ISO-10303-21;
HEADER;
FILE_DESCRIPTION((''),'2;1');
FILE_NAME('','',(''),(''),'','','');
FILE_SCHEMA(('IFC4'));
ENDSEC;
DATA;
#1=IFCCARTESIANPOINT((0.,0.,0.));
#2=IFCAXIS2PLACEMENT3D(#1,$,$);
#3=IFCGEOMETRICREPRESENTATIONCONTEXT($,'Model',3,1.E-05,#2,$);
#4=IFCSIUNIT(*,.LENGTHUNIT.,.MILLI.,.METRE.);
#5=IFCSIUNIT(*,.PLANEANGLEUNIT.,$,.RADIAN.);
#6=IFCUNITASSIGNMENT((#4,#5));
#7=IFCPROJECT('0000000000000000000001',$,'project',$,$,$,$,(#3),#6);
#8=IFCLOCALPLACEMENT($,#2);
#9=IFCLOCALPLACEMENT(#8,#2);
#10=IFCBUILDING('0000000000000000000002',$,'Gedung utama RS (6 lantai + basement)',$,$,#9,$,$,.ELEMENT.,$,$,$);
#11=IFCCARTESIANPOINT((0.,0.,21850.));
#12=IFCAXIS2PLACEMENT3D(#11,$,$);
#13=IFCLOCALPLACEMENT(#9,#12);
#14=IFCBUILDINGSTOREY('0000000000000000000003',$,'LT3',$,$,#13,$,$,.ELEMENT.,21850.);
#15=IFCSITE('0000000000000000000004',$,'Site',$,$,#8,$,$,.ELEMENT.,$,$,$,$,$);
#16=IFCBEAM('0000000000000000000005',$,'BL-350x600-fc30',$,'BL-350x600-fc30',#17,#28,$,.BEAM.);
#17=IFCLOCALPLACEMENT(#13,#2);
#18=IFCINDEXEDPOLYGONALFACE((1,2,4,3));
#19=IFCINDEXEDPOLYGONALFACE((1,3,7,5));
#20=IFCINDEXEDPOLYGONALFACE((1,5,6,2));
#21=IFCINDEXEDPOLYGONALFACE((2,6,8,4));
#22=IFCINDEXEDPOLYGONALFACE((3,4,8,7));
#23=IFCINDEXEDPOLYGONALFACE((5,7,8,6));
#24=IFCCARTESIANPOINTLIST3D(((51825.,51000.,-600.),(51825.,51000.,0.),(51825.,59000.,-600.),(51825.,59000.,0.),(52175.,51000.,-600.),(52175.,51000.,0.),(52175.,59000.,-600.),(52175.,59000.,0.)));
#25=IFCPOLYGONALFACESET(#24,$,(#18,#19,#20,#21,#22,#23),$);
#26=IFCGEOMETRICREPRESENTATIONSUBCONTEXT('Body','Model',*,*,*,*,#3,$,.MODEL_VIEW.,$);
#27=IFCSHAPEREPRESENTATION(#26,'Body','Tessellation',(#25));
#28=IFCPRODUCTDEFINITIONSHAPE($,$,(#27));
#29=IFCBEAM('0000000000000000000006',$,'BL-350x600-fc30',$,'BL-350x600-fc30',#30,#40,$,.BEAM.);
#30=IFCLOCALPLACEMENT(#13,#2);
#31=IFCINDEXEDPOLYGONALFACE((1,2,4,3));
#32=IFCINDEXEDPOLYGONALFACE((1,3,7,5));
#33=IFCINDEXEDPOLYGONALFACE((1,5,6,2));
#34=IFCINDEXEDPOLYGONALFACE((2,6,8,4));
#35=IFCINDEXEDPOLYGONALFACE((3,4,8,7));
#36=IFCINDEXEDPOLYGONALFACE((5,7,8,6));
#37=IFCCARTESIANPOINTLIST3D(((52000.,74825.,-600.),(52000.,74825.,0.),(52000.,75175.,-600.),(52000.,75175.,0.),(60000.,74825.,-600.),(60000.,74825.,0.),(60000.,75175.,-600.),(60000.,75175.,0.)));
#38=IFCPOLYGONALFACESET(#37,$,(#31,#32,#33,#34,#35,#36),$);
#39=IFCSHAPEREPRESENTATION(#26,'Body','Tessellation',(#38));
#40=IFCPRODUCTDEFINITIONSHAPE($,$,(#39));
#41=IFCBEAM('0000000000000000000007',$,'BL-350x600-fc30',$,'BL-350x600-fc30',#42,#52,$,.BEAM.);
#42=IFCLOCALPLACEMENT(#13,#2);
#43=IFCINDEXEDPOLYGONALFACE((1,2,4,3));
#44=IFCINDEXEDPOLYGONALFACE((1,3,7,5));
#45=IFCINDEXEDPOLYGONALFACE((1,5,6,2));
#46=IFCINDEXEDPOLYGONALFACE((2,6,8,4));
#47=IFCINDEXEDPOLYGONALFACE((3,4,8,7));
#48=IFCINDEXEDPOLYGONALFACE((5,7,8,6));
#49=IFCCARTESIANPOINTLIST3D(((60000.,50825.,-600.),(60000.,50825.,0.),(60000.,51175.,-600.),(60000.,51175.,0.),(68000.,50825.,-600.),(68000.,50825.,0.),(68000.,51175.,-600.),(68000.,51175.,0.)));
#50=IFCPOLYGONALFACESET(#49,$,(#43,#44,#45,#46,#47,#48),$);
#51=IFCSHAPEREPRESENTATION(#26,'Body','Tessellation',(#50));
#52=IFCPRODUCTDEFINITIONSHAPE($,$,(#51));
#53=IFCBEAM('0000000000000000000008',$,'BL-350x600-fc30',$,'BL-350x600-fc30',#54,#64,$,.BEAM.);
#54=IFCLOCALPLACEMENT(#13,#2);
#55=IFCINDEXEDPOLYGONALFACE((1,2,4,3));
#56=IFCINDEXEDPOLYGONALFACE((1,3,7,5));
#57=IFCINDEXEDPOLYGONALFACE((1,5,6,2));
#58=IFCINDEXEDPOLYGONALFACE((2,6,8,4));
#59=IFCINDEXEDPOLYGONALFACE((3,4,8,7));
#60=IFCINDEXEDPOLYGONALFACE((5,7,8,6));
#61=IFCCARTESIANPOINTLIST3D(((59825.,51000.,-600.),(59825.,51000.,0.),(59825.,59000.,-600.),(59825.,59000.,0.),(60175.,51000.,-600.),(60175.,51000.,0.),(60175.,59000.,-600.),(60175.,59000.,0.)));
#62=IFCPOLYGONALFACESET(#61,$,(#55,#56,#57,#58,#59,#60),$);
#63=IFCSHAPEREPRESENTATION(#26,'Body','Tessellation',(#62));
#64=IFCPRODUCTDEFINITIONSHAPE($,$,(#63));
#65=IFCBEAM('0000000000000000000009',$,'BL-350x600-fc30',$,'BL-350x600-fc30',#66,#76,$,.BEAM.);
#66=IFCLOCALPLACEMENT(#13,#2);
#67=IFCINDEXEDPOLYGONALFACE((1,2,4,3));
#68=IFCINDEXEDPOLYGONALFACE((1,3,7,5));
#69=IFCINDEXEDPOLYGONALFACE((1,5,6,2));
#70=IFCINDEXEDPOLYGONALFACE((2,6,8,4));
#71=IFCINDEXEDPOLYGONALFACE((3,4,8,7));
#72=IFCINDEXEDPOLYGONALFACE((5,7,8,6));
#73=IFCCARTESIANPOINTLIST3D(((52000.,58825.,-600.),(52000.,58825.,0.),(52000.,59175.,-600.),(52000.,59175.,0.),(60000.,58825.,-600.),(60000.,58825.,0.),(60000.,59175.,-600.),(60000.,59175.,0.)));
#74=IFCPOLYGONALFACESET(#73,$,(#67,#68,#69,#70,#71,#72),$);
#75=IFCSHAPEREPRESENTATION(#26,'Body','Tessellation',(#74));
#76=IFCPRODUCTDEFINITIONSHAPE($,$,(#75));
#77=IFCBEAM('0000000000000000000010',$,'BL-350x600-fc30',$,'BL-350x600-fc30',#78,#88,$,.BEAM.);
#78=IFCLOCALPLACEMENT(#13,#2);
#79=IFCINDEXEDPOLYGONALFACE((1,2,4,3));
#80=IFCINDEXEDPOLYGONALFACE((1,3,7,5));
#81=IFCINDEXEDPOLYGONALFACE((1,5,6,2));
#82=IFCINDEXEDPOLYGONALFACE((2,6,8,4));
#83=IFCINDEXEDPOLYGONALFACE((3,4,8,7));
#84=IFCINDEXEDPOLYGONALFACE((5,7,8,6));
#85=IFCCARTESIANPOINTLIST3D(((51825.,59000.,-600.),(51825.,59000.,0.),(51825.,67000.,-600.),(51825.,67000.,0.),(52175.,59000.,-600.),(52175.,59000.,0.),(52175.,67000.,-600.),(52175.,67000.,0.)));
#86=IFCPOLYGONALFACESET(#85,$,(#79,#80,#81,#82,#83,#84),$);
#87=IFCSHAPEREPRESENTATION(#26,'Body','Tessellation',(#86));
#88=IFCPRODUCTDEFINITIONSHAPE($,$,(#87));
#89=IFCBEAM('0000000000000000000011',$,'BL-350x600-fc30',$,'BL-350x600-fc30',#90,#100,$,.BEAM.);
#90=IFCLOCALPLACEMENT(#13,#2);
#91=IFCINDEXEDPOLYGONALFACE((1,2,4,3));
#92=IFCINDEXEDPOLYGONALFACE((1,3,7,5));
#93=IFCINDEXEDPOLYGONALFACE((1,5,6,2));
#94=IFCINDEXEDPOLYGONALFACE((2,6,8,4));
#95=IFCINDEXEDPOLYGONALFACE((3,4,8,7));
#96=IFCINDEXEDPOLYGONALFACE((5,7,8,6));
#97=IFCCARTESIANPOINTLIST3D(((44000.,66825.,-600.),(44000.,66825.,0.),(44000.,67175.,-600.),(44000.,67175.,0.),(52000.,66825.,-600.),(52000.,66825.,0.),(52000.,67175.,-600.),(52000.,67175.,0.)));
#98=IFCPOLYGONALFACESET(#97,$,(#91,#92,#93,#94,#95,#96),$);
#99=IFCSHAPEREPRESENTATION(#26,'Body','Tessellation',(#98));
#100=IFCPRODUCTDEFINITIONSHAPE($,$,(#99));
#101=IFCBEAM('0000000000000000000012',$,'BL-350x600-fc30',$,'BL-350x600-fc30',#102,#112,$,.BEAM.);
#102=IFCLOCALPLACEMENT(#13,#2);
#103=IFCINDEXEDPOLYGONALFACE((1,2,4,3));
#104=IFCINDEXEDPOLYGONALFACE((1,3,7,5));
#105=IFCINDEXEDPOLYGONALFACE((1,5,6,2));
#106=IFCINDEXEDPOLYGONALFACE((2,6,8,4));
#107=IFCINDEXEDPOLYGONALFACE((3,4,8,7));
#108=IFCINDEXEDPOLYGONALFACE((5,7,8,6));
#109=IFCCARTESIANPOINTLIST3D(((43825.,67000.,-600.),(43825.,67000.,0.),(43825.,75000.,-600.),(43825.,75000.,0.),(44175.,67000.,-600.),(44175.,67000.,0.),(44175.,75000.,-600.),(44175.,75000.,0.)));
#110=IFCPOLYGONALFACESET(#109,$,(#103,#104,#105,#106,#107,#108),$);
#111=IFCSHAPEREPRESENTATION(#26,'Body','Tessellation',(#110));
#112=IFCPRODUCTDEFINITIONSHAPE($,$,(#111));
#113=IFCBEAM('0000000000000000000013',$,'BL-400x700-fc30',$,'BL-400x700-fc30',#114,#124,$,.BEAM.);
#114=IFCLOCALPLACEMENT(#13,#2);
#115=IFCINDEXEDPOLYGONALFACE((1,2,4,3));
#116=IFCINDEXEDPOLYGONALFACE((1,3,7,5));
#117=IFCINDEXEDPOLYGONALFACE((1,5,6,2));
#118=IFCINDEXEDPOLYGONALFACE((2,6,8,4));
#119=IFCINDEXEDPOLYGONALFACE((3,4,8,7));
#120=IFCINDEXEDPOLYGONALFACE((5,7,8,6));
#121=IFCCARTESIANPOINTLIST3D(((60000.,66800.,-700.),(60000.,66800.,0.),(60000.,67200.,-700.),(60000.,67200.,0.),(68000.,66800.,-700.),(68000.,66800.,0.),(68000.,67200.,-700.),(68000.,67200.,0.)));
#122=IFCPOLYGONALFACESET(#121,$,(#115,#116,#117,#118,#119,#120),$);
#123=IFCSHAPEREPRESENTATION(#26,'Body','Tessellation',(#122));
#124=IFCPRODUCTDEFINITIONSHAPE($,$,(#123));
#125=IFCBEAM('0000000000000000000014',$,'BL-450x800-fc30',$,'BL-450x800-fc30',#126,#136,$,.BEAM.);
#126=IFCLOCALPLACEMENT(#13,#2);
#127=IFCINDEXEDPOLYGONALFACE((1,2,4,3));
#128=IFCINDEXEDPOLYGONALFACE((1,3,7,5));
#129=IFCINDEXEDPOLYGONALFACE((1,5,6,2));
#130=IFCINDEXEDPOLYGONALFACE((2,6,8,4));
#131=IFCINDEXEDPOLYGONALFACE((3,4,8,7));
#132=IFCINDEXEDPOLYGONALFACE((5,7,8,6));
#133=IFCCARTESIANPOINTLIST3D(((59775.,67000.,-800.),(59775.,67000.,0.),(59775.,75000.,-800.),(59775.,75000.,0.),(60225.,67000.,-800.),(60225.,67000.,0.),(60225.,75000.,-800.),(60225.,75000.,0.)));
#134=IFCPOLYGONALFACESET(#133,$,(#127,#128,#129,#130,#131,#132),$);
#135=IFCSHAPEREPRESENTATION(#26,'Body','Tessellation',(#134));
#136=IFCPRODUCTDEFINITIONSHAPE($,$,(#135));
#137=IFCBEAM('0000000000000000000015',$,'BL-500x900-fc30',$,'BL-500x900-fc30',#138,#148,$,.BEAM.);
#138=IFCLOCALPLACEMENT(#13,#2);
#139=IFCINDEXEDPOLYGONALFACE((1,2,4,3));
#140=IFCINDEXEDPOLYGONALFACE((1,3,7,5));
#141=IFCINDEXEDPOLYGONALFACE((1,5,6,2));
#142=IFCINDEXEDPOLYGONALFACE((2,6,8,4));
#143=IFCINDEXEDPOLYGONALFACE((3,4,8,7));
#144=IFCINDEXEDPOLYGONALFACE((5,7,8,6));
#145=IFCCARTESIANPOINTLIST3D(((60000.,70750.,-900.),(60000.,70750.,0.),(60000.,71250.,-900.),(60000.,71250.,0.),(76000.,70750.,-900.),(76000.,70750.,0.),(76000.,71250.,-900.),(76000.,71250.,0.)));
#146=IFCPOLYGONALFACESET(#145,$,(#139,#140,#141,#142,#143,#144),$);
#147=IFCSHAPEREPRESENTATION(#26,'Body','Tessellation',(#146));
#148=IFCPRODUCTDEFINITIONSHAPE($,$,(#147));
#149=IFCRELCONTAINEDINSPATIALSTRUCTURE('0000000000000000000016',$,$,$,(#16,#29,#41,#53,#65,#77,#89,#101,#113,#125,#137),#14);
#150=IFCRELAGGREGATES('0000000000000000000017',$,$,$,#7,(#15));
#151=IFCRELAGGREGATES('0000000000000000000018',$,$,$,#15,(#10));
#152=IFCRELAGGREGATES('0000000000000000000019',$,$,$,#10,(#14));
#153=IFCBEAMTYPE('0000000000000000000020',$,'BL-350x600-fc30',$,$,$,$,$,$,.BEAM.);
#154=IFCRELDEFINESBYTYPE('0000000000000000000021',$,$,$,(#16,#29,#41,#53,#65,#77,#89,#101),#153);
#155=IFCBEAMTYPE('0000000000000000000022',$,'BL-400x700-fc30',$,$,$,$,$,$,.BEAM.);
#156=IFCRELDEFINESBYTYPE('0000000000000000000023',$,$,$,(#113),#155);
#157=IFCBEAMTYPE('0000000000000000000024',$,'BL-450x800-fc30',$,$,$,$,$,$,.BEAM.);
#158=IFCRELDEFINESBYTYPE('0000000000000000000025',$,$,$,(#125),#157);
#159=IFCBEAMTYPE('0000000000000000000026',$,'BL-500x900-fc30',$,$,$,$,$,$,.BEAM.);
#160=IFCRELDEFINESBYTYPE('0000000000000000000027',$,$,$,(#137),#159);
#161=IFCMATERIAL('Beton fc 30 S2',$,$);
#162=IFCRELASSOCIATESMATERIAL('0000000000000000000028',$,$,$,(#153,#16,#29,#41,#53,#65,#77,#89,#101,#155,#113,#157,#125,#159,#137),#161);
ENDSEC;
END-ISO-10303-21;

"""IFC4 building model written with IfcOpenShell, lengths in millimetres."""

from ifc_helpers import new_model, si_unit, frame, origin, origin_2d, place, context, subcontext, project, spatial, rectangle, extrude, material, material_profile, profile_set, profile_usage, type_object, element, save


model = new_model("IFC4")

# Units and contexts
model_context = context("Model", 3, precision=1e-05, world=origin())
body_context = subcontext(model_context, "Body", "Model", "MODEL_VIEW")
ifc_project = project(units=[si_unit("LENGTHUNIT", "METRE", prefix="MILLI"), si_unit("PLANEANGLEUNIT", "RADIAN")], contexts=[model_context])

# Site, building, storey
site_placement = place(None, origin())
site = spatial("IfcSite", under=ifc_project, at=site_placement, Name="Site", CompositionType="ELEMENT")
building_placement = place(site_placement, origin())
building = spatial("IfcBuilding", under=site, at=building_placement, Name="Gedung utama RS (6 lantai + basement)", CompositionType="ELEMENT")
storey_placement = place(building_placement, frame((0.0, 0.0, 21850.0)))
storey = spatial("IfcBuildingStorey", under=building, at=storey_placement, Name="LT3", CompositionType="ELEMENT", Elevation=21850.0)

# Beams
ifc_material = material(Name="Beton fc 30 S2")
ifc_material_profile_1 = material_profile(ifc_material, rectangle(XDim=350.0, YDim=600.0, at=origin_2d()), Name="BL-350x600-fc30")
ifc_profile_set_1 = profile_set([ifc_material_profile_1], Name="BL-350x600-fc30")
ifc_profile_usage_1 = profile_usage(ifc_profile_set_1, cardinal=8)
beam_type_1 = type_object("IfcBeamType", Name="BL-350x600-fc30", PredefinedType="BEAM", material=ifc_profile_set_1)
beam_1_placement = place(storey_placement, frame((52000.0, 51000.0, -300.0)))
element("IfcBeam", 1, at=beam_1_placement, inside=storey, type_object=beam_type_1, material=ifc_profile_usage_1, Name="BL-350x600-fc30", ObjectType="BL-350x600-fc30", PredefinedType="BEAM", context=body_context, shape_type="SweptSolid", body=[
    extrude(rectangle(XDim=350.0, YDim=600.0, at=origin_2d()), frame((0.0, 0.0, 0.0), z_axis=(0.0, 1.0, 0.0), x_axis=(-1.0, 0.0, 0.0)), (0.0, 0.0, 1.0), 8000.0),
])
for number, where, name in (
    (2, (52000.0, 75000.0, -300.0), "BL-350x600-fc30"),
    (3, (60000.0, 51000.0, -300.0), "BL-350x600-fc30"),
):
    element("IfcBeam", number, at=place(storey_placement, frame(where)), inside=storey, type_object=beam_type_1, material=ifc_profile_usage_1, Name=name, ObjectType="BL-350x600-fc30", PredefinedType="BEAM", context=body_context, shape_type="SweptSolid", body=[
        extrude(rectangle(XDim=350.0, YDim=600.0, at=origin_2d()), frame((0.0, 0.0, 0.0), z_axis=(1.0, 0.0, 0.0), x_axis=(0.0, 1.0, 0.0)), (0.0, 0.0, 1.0), 8000.0),
    ])
beam_2_placement = place(storey_placement, frame((60000.0, 51000.0, -300.0)))
element("IfcBeam", 4, at=beam_2_placement, inside=storey, type_object=beam_type_1, material=ifc_profile_usage_1, Name="BL-350x600-fc30", ObjectType="BL-350x600-fc30", PredefinedType="BEAM", context=body_context, shape_type="SweptSolid", body=[
    extrude(rectangle(XDim=350.0, YDim=600.0, at=origin_2d()), frame((0.0, 0.0, 0.0), z_axis=(0.0, 1.0, 0.0), x_axis=(-1.0, 0.0, 0.0)), (0.0, 0.0, 1.0), 8000.0),
])
beam_3_placement = place(storey_placement, frame((52000.0, 59000.0, -300.0)))
element("IfcBeam", 5, at=beam_3_placement, inside=storey, type_object=beam_type_1, material=ifc_profile_usage_1, Name="BL-350x600-fc30", ObjectType="BL-350x600-fc30", PredefinedType="BEAM", context=body_context, shape_type="SweptSolid", body=[
    extrude(rectangle(XDim=350.0, YDim=600.0, at=origin_2d()), frame((0.0, 0.0, 0.0), z_axis=(1.0, 0.0, 0.0), x_axis=(0.0, 1.0, 0.0)), (0.0, 0.0, 1.0), 8000.0),
])
beam_4_placement = place(storey_placement, frame((52000.0, 59000.0, -300.0)))
element("IfcBeam", 6, at=beam_4_placement, inside=storey, type_object=beam_type_1, material=ifc_profile_usage_1, Name="BL-350x600-fc30", ObjectType="BL-350x600-fc30", PredefinedType="BEAM", context=body_context, shape_type="SweptSolid", body=[
    extrude(rectangle(XDim=350.0, YDim=600.0, at=origin_2d()), frame((0.0, 0.0, 0.0), z_axis=(0.0, 1.0, 0.0), x_axis=(-1.0, 0.0, 0.0)), (0.0, 0.0, 1.0), 8000.0),
])
beam_5_placement = place(storey_placement, frame((44000.0, 67000.0, -300.0)))
element("IfcBeam", 7, at=beam_5_placement, inside=storey, type_object=beam_type_1, material=ifc_profile_usage_1, Name="BL-350x600-fc30", ObjectType="BL-350x600-fc30", PredefinedType="BEAM", context=body_context, shape_type="SweptSolid", body=[
    extrude(rectangle(XDim=350.0, YDim=600.0, at=origin_2d()), frame((0.0, 0.0, 0.0), z_axis=(1.0, 0.0, 0.0), x_axis=(0.0, 1.0, 0.0)), (0.0, 0.0, 1.0), 8000.0),
])
beam_6_placement = place(storey_placement, frame((44000.0, 67000.0, -300.0)))
element("IfcBeam", 8, at=beam_6_placement, inside=storey, type_object=beam_type_1, material=ifc_profile_usage_1, Name="BL-350x600-fc30", ObjectType="BL-350x600-fc30", PredefinedType="BEAM", context=body_context, shape_type="SweptSolid", body=[
    extrude(rectangle(XDim=350.0, YDim=600.0, at=origin_2d()), frame((0.0, 0.0, 0.0), z_axis=(0.0, 1.0, 0.0), x_axis=(-1.0, 0.0, 0.0)), (0.0, 0.0, 1.0), 8000.0),
])
ifc_material_profile_2 = material_profile(ifc_material, rectangle(XDim=400.0, YDim=700.0, at=origin_2d()), Name="BL-400x700-fc30")
ifc_profile_set_2 = profile_set([ifc_material_profile_2], Name="BL-400x700-fc30")
ifc_profile_usage_2 = profile_usage(ifc_profile_set_2, cardinal=8)
beam_type_2 = type_object("IfcBeamType", Name="BL-400x700-fc30", PredefinedType="BEAM", material=ifc_profile_set_2)
beam_7_placement = place(storey_placement, frame((60000.0, 67000.0, -350.0)))
element("IfcBeam", 9, at=beam_7_placement, inside=storey, type_object=beam_type_2, material=ifc_profile_usage_2, Name="BL-400x700-fc30", ObjectType="BL-400x700-fc30", PredefinedType="BEAM", context=body_context, shape_type="SweptSolid", body=[
    extrude(rectangle(XDim=400.0, YDim=700.0, at=origin_2d()), frame((0.0, 0.0, 0.0), z_axis=(1.0, 0.0, 0.0), x_axis=(0.0, 1.0, 0.0)), (0.0, 0.0, 1.0), 8000.0),
])
ifc_material_profile_3 = material_profile(ifc_material, rectangle(XDim=450.0, YDim=800.0, at=origin_2d()), Name="BL-450x800-fc30")
ifc_profile_set_3 = profile_set([ifc_material_profile_3], Name="BL-450x800-fc30")
ifc_profile_usage_3 = profile_usage(ifc_profile_set_3, cardinal=8)
beam_type_3 = type_object("IfcBeamType", Name="BL-450x800-fc30", PredefinedType="BEAM", material=ifc_profile_set_3)
beam_8_placement = place(storey_placement, frame((60000.0, 67000.0, -400.0)))
element("IfcBeam", 10, at=beam_8_placement, inside=storey, type_object=beam_type_3, material=ifc_profile_usage_3, Name="BL-450x800-fc30", ObjectType="BL-450x800-fc30", PredefinedType="BEAM", context=body_context, shape_type="SweptSolid", body=[
    extrude(rectangle(XDim=450.0, YDim=800.0, at=origin_2d()), frame((0.0, 0.0, 0.0), z_axis=(0.0, 1.0, 0.0), x_axis=(-1.0, 0.0, 0.0)), (0.0, 0.0, 1.0), 8000.0),
])
ifc_material_profile_4 = material_profile(ifc_material, rectangle(XDim=500.0, YDim=900.0, at=origin_2d()), Name="BL-500x900-fc30")
ifc_profile_set_4 = profile_set([ifc_material_profile_4], Name="BL-500x900-fc30")
ifc_profile_usage_4 = profile_usage(ifc_profile_set_4, cardinal=8)
beam_type_4 = type_object("IfcBeamType", Name="BL-500x900-fc30", PredefinedType="BEAM", material=ifc_profile_set_4)
beam_9_placement = place(storey_placement, frame((60000.0, 71000.0, -450.0)))
element("IfcBeam", 11, at=beam_9_placement, inside=storey, type_object=beam_type_4, material=ifc_profile_usage_4, Name="BL-500x900-fc30", ObjectType="BL-500x900-fc30", PredefinedType="BEAM", context=body_context, shape_type="SweptSolid", body=[
    extrude(rectangle(XDim=500.0, YDim=900.0, at=origin_2d()), frame((0.0, 0.0, 0.0), z_axis=(1.0, 0.0, 0.0), x_axis=(0.0, 1.0, 0.0)), (0.0, 0.0, 1.0), 16000.0),
])

save(model, "model.ifc")
